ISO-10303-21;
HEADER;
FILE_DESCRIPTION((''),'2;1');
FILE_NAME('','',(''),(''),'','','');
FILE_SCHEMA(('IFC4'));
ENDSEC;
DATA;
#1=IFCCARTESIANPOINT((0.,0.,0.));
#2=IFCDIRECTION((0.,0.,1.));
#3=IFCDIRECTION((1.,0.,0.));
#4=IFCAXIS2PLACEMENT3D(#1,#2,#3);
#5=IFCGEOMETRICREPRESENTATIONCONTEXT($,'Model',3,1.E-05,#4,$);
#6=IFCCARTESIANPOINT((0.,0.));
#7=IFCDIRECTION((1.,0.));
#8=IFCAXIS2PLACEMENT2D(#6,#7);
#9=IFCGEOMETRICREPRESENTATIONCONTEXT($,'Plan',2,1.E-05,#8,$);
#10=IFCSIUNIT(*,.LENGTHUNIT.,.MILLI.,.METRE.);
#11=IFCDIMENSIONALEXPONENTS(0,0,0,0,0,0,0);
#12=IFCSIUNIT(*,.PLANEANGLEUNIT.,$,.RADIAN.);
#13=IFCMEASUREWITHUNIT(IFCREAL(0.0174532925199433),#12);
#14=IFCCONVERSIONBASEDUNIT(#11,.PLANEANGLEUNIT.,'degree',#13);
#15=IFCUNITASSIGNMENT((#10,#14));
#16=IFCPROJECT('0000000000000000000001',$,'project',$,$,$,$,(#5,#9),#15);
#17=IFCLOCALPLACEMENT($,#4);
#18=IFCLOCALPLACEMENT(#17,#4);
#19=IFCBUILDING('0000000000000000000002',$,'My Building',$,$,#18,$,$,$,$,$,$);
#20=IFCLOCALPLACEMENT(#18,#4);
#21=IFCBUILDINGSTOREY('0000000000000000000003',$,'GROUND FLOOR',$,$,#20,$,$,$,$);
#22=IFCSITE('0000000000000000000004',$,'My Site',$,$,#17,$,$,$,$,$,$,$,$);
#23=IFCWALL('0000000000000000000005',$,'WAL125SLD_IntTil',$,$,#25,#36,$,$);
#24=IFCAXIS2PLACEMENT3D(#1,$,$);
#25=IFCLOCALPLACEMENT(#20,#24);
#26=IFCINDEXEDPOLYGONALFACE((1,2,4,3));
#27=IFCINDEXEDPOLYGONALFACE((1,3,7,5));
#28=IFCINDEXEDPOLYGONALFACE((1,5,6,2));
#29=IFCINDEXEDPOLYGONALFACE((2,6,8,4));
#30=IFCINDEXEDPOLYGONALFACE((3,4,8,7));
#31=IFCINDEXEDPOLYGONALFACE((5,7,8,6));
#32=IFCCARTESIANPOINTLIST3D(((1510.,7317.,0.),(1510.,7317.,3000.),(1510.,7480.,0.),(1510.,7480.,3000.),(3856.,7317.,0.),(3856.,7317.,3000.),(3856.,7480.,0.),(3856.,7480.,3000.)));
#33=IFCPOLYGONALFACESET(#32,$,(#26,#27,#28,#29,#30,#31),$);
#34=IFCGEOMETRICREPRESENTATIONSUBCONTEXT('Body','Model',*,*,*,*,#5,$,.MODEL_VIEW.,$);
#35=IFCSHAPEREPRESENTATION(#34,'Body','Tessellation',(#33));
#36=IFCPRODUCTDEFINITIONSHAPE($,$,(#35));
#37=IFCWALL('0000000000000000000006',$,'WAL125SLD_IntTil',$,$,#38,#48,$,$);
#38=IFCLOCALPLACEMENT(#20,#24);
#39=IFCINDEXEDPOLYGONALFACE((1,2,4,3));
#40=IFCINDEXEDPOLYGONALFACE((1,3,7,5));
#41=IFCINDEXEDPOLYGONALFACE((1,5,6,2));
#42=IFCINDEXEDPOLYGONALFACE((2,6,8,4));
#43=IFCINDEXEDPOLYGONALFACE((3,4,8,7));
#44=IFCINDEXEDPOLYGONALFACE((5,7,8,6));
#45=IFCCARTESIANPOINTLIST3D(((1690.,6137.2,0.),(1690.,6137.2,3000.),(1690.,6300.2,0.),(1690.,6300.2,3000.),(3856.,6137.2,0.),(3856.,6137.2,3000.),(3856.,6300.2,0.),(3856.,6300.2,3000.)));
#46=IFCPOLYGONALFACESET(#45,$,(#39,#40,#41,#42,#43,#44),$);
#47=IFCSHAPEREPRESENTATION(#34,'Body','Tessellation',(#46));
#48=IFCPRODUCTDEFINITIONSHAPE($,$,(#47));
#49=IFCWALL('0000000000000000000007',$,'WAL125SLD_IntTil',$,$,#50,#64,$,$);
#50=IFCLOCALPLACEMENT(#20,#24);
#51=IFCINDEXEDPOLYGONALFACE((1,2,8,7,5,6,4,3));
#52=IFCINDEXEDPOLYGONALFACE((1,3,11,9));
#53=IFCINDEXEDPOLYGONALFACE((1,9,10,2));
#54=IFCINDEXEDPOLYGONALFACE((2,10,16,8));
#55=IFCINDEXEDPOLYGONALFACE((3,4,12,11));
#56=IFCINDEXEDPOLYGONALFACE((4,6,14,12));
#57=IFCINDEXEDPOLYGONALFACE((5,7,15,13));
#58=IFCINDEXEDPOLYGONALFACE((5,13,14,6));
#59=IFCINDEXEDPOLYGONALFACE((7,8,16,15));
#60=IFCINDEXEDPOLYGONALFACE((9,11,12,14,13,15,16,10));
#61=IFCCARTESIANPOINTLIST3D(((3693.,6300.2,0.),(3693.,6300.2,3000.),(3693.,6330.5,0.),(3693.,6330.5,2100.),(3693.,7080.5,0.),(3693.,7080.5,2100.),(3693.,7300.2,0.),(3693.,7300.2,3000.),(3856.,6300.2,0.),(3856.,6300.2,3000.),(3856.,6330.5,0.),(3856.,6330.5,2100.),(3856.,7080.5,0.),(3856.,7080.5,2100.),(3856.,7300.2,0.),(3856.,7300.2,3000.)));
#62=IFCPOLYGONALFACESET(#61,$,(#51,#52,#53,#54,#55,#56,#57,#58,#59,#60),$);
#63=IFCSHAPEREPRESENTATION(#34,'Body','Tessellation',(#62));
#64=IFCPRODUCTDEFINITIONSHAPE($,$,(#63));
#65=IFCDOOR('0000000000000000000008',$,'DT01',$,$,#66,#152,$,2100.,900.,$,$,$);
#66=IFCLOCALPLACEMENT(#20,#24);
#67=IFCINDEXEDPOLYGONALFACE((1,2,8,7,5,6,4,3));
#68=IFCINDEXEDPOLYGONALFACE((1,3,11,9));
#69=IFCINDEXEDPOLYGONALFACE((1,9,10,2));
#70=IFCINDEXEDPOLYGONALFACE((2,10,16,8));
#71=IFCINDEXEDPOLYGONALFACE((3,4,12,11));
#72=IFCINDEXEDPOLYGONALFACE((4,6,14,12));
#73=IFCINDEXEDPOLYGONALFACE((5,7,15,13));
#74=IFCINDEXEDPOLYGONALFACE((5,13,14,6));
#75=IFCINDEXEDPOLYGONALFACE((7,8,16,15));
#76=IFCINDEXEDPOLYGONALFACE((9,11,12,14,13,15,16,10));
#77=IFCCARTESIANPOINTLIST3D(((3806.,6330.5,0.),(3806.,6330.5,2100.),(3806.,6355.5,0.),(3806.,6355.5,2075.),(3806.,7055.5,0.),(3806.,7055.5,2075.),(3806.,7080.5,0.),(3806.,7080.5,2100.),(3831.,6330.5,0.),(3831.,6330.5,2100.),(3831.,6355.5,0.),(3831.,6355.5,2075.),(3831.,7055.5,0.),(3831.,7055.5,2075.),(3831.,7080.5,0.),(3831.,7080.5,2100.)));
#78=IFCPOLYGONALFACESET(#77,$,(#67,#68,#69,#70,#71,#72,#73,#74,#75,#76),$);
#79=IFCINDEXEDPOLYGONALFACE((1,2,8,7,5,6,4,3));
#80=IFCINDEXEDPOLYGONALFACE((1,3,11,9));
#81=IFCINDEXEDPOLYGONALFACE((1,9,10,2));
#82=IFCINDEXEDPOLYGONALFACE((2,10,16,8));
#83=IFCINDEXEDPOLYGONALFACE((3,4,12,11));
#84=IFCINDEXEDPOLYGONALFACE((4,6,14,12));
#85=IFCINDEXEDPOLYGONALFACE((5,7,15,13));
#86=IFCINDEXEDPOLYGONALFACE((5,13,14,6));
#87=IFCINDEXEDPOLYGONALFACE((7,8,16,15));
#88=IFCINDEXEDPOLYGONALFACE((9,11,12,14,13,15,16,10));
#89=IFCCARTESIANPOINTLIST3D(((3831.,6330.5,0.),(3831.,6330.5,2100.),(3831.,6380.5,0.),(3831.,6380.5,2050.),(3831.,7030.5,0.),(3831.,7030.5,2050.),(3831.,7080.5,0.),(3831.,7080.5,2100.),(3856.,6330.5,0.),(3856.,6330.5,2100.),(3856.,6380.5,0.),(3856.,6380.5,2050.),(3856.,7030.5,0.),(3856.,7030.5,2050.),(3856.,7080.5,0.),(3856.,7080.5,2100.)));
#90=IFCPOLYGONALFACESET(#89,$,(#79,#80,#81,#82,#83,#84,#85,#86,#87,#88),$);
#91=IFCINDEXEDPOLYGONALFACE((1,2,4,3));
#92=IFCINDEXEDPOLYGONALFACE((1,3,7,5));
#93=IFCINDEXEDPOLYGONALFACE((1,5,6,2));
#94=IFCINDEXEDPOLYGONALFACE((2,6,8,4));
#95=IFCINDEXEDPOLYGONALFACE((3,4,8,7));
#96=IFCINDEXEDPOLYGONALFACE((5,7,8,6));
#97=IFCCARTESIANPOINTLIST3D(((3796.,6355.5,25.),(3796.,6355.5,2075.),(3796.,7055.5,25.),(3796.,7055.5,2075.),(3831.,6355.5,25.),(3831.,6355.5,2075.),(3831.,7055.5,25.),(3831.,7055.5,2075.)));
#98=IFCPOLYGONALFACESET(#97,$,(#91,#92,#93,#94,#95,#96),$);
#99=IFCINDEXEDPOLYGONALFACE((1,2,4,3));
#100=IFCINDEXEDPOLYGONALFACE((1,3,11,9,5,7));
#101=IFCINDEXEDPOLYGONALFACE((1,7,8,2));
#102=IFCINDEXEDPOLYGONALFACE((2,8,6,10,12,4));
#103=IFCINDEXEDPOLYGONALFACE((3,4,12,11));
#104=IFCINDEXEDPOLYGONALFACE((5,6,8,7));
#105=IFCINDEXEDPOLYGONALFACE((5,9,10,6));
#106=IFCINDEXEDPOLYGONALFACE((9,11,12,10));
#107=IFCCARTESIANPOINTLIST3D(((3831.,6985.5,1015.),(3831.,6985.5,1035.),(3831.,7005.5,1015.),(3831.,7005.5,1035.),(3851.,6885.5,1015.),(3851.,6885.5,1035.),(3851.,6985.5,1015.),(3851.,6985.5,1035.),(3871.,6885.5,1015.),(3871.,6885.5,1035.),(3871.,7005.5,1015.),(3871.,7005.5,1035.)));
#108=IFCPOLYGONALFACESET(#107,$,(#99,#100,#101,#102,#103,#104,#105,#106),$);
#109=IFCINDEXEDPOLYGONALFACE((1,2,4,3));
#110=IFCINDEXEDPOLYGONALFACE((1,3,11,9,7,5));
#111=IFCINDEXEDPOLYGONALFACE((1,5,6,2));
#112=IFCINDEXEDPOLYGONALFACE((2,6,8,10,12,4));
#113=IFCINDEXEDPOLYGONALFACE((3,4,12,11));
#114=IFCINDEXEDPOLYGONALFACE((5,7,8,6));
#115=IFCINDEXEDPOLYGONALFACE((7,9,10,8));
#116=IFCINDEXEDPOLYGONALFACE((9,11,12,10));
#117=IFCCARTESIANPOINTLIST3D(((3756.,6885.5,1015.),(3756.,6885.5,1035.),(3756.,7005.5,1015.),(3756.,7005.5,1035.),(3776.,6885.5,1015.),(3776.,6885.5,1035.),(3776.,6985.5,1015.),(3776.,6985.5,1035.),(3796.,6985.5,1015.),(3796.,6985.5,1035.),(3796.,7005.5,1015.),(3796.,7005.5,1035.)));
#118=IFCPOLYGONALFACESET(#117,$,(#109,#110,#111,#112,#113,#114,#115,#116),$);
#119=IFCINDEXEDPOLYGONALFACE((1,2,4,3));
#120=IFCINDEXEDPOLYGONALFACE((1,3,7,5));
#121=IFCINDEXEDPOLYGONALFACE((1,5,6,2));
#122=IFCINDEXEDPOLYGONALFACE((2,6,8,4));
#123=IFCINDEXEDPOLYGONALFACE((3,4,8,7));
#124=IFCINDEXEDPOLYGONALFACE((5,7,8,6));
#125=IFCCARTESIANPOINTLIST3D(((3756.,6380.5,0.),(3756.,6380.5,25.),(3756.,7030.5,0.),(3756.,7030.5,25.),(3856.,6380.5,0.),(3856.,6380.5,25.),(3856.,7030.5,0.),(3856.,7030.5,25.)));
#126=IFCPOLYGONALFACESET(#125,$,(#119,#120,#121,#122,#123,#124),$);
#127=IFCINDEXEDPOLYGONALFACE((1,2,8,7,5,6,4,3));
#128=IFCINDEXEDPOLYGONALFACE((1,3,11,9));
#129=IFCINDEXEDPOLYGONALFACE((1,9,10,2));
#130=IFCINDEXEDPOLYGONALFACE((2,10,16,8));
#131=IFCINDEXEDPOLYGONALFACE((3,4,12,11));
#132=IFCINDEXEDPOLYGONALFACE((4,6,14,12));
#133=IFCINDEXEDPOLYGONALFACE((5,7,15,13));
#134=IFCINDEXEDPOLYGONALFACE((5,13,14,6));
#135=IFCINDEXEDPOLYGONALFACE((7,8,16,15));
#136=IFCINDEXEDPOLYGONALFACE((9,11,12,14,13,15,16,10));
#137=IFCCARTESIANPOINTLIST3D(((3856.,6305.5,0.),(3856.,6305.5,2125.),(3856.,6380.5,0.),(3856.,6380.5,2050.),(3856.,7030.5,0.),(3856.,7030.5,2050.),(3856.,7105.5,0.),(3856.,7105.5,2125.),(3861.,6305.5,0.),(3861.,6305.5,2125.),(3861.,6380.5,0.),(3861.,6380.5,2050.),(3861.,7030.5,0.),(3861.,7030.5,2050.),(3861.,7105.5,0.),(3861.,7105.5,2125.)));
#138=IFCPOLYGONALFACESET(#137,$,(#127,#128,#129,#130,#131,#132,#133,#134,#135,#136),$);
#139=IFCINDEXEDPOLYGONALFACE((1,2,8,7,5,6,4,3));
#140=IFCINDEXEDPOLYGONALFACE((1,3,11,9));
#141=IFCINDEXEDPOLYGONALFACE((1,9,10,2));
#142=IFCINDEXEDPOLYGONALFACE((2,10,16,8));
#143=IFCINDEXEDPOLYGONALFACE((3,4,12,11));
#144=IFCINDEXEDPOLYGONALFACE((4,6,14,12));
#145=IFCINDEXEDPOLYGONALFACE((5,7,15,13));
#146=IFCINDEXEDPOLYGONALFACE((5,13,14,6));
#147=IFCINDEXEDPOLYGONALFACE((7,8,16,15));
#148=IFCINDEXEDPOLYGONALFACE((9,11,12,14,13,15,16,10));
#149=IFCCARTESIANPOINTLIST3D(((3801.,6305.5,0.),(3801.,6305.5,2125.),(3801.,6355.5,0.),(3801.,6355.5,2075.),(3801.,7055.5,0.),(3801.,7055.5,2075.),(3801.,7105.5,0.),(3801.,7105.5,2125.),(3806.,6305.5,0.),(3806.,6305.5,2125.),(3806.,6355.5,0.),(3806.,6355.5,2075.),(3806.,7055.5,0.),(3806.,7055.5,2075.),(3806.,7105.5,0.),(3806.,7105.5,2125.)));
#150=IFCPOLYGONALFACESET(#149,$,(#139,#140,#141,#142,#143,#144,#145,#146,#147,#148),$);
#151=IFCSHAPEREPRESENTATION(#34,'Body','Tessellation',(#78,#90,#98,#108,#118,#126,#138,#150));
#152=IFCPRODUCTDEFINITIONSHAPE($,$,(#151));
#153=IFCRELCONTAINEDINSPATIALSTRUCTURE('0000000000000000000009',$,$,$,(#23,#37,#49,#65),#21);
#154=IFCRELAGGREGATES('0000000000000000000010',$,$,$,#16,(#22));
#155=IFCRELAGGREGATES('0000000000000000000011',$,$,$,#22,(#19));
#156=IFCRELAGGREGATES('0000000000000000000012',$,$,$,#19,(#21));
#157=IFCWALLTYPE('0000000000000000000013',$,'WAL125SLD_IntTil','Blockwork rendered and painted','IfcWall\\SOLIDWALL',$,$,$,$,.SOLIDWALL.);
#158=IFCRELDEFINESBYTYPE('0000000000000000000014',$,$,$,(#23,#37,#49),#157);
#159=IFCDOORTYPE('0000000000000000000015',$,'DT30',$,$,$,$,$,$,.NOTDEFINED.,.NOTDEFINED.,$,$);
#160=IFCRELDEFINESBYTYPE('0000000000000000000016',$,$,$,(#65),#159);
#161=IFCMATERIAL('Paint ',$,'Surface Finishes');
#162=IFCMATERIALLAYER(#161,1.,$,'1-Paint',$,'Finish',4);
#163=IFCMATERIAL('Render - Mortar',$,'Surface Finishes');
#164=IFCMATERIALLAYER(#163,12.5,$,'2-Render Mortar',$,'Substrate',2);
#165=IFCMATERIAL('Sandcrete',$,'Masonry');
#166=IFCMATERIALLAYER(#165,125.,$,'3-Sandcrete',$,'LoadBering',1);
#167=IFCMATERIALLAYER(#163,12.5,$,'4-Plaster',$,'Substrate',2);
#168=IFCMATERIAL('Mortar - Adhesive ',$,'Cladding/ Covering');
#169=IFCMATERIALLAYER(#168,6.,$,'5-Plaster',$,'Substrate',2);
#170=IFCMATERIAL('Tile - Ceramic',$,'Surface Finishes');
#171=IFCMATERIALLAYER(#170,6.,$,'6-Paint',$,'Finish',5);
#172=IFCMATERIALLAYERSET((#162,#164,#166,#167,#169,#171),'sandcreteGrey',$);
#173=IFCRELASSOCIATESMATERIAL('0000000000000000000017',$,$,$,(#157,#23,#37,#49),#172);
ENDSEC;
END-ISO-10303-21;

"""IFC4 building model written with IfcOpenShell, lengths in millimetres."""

from ifc_helpers import new_model, entity, si_unit, converted_unit, frame, origin_with_axes, origin_2d_with_axis, place, context, subcontext, project, spatial, line, indexed_curve, outline, extrude, shape, source, transform, mapped, material, layer, layer_set, layer_usage, type_object, type_shapes, element, fill, save


model = new_model("IFC4")

# Units and contexts
model_context = context("Model", 3, precision=1e-05, world=origin_with_axes())
plan_context = context("Plan", 2, precision=1e-05, world=origin_2d_with_axis())
body_context_1 = subcontext(model_context, "Body", "Model", "MODEL_VIEW")
body_context_2 = subcontext(plan_context, "Body", "Plan", "PLAN_VIEW")
ifc_project = project(units=[si_unit("LENGTHUNIT", "METRE", prefix="MILLI"), converted_unit("PLANEANGLEUNIT", "degree", entity("IfcReal", 0.0174532925199433), si_unit("PLANEANGLEUNIT", "RADIAN"), dimensions=[0, 0, 0, 0, 0, 0, 0])], contexts=[model_context, plan_context])

# Site, building, storey
site_placement = place(None, origin_with_axes())
site = spatial("IfcSite", under=ifc_project, at=site_placement, Name="My Site")
building_placement = place(site_placement, origin_with_axes())
building = spatial("IfcBuilding", under=site, at=building_placement, Name="My Building")
storey_placement = place(building_placement, origin_with_axes())
storey = spatial("IfcBuildingStorey", under=building, at=storey_placement, Name="GROUND FLOOR")

# Walls
ifc_material_1 = material(Name="Paint ", Category="Surface Finishes")
ifc_layer_1 = layer(ifc_material_1, 1.0, Name="1-Paint", Category="Finish", Priority=4)
ifc_material_2 = material(Name="Render - Mortar", Category="Surface Finishes")
ifc_layer_2 = layer(ifc_material_2, 12.5, Name="2-Render Mortar", Category="Substrate", Priority=2)
ifc_material_3 = material(Name="Sandcrete", Category="Masonry")
ifc_layer_3 = layer(ifc_material_3, 125.0, Name="3-Sandcrete", Category="LoadBering", Priority=1)
ifc_layer_4 = layer(ifc_material_2, 12.5, Name="4-Plaster", Category="Substrate", Priority=2)
ifc_material_4 = material(Name="Mortar - Adhesive ", Category="Cladding/ Covering")
ifc_layer_5 = layer(ifc_material_4, 6.0, Name="5-Plaster", Category="Substrate", Priority=2)
ifc_material_5 = material(Name="Tile - Ceramic", Category="Surface Finishes")
ifc_layer_6 = layer(ifc_material_5, 6.0, Name="6-Paint", Category="Finish", Priority=5)
ifc_layer_set_1 = layer_set([ifc_layer_1, ifc_layer_2, ifc_layer_3, ifc_layer_4, ifc_layer_5, ifc_layer_6], Name="sandcreteGrey")
ifc_layer_usage_1 = layer_usage(ifc_layer_set_1, "AXIS2", "POSITIVE", 0.0)
wall_type_1 = type_object("IfcWallType", Name="WAL125SLD_IntTil", Description="Blockwork rendered and painted", ApplicableOccurrence="IfcWall\\SOLIDWALL", PredefinedType="SOLIDWALL", material=ifc_layer_set_1)
wall_1_placement = place(storey_placement, frame((3856.0, 7480.0, 0.0), z_axis=(0.0, 0.0, 1.0), x_axis=(-1.0, 0.0, 0.0)))
element("IfcWall", 1, at=wall_1_placement, inside=storey, type_object=wall_type_1, material=ifc_layer_usage_1, Name="WAL125SLD_IntTil", context=body_context_1, shape_type="SweptSolid", body=[
    extrude(outline(indexed_curve([(0.0, 0.0), (0.0, 163.0), (2346.0, 163.0), (2346.0, 0.0), (0.0, 0.0)], self_intersect=False)), origin_with_axes(), (0.0, 0.0, 1.0), 3000.0),
])
ifc_layer_usage_2 = layer_usage(ifc_layer_set_1, "AXIS2", "POSITIVE", 0.0)
wall_2_placement = place(storey_placement, frame((1690.0, 6137.2, 0.0), z_axis=(0.0, 0.0, 1.0), x_axis=(1.0, 0.0, 0.0)))
element("IfcWall", 2, at=wall_2_placement, inside=storey, type_object=wall_type_1, material=ifc_layer_usage_2, Name="WAL125SLD_IntTil", context=body_context_1, shape_type="SweptSolid", body=[
    extrude(outline(indexed_curve([(0.0, 0.0), (0.0, 163.0), (2166.0, 163.0), (2166.0, 0.0), (0.0, 0.0)], self_intersect=False)), origin_with_axes(), (0.0, 0.0, 1.0), 3000.0),
])

# Wall, opening, door
ifc_layer_usage_3 = layer_usage(ifc_layer_set_1, "AXIS2", "POSITIVE", 0.0)
wall_3_placement = place(storey_placement, frame((3856.0, 6300.2, 0.0), z_axis=(0.0, 0.0, 1.0), x_axis=(0.0, 1.0, 0.0)))
wall_3 = element("IfcWall", 3, at=wall_3_placement, inside=storey, type_object=wall_type_1, material=ifc_layer_usage_3, Name="WAL125SLD_IntTil", context=body_context_1, shape_type="SweptSolid", body=[
    extrude(outline(indexed_curve([(0.0, 0.0), (0.0, 163.0), (1000.0, 163.0), (1000.0, 0.0), (0.0, 0.0)], self_intersect=False)), origin_with_axes(), (0.0, 0.0, 1.0), 3000.0),
])
shared_shape_1 = source(origin_with_axes(), body_context_1, "Body", "SweptSolid", [
    extrude(outline(indexed_curve([(0.0, 0.0), (750.0, 0.0), (750.0, 2100.0), (0.0, 2100.0)], segments=[line(1, 2, 3, 4, 1)])), frame((0.0, -100.0, 0.0), z_axis=(0.0, -1.0, 0.0), x_axis=(1.0, 0.0, 0.0)), (0.0, 0.0, -1.0), 380.0),
])
opening_1_placement = place(wall_3_placement, frame((30.4, 0.0, 0.0), z_axis=(0.0, 0.0, 1.0), x_axis=(1.0, 0.0, 0.0)))
opening_1 = element("IfcOpeningElement", 4, at=opening_1_placement, cuts=wall_3, PredefinedType="OPENING", context=body_context_1, shape_type="MappedRepresentation", body=[
    mapped(shared_shape_1, transform((0.0, 0.0, 0.0), x_axis=(1.0, 0.0, 0.0), y_axis=(0.0, 1.0, 0.0), z_axis=(0.0, 0.0, 1.0), scale=1.0)),
])
door_type = type_object("IfcDoorType", Name="DT30", OperationType="NOTDEFINED", PredefinedType="NOTDEFINED")
shared_shape_2 = source(origin_with_axes(), body_context_1, "Body", "SweptSolid", [
    extrude(outline(indexed_curve([(0.0, 0.0), (0.0, 2100.0), (750.0, 2100.0), (750.0, 0.0), (725.0, 0.0), (725.0, 2075.0), (25.0, 2075.0), (25.0, 0.0)], segments=[line(1, 2, 3, 4, 5, 6, 7, 8, 1)])), frame((0.0, 25.0, 0.0), z_axis=(0.0, -1.0, 0.0), x_axis=(1.0, 0.0, 0.0)), (0.0, 0.0, -1.0), 25.0),
    extrude(outline(indexed_curve([(0.0, 0.0), (0.0, 2100.0), (750.0, 2100.0), (750.0, 0.0), (700.0, 0.0), (700.0, 2050.0), (50.0, 2050.0), (50.0, 0.0)], segments=[line(1, 2, 3, 4, 5, 6, 7, 8, 1)])), frame((0.0, 0.0, 0.0), z_axis=(0.0, -1.0, 0.0), x_axis=(1.0, 0.0, 0.0)), (0.0, 0.0, -1.0), 25.0),
    extrude(outline(indexed_curve([(0.0, 0.0), (700.0, 0.0), (700.0, 35.0), (0.0, 35.0)], segments=[line(1, 2, 3, 4, 1)])), frame((25.0, 25.0, 25.0), z_axis=(0.0, 0.0, 1.0), x_axis=(1.0, 0.0, 0.0)), (0.0, 0.0, 1.0), 2050.0),
    extrude(outline(indexed_curve([(0.0, 0.0), (0.0, -40.0), (-120.0, -40.0), (-120.0, -20.0), (-20.0, -20.0), (-20.0, 0.0)], segments=[line(1, 2, 3, 4, 5, 6, 1)])), frame((675.0, 25.0, 1015.0), z_axis=(0.0, 0.0, 1.0), x_axis=(1.0, 0.0, 0.0)), (0.0, 0.0, 1.0), 20.0),
    extrude(outline(indexed_curve([(0.0, 0.0), (0.0, 40.0), (-120.0, 40.0), (-120.0, 20.0), (-20.0, 20.0), (-20.0, 0.0)], segments=[line(1, 2, 3, 4, 5, 6, 1)])), frame((675.0, 60.0, 1015.0), z_axis=(0.0, 0.0, 1.0), x_axis=(1.0, 0.0, 0.0)), (0.0, 0.0, 1.0), 20.0),
    extrude(outline(indexed_curve([(0.0, 0.0), (650.0, 0.0), (650.0, 100.0), (0.0, 100.0)], segments=[line(1, 2, 3, 4, 1)])), frame((50.0, 0.0, 0.0), z_axis=(0.0, 0.0, 1.0), x_axis=(1.0, 0.0, 0.0)), (0.0, 0.0, 1.0), 25.0),
    extrude(outline(indexed_curve([(0.0, 0.0), (0.0, 2125.0), (800.0, 2125.0), (800.0, 0.0), (725.0, 0.0), (725.0, 2050.0), (75.0, 2050.0), (75.0, 0.0)], segments=[line(1, 2, 3, 4, 5, 6, 7, 8, 1)])), frame((-25.0, -5.0, 0.0), z_axis=(0.0, -1.0, 0.0), x_axis=(1.0, 0.0, 0.0)), (0.0, 0.0, -1.0), 5.0),
    extrude(outline(indexed_curve([(0.0, 0.0), (0.0, 2125.0), (800.0, 2125.0), (800.0, 0.0), (750.0, 0.0), (750.0, 2075.0), (50.0, 2075.0), (50.0, 0.0)], segments=[line(1, 2, 3, 4, 5, 6, 7, 8, 1)])), frame((-25.0, 50.0, 0.0), z_axis=(0.0, -1.0, 0.0), x_axis=(1.0, 0.0, 0.0)), (0.0, 0.0, -1.0), 5.0),
])
shared_shape_3 = source(origin_with_axes(), body_context_2, "Body", "Curve2D", [
    entity("IfcIndexedPolyCurve", entity("IfcCartesianPointList2D", [[0.0, 0.0], [0.0, 50.0], [25.0, 50.0], [25.0, 25.0], [50.0, 25.0], [50.0, 0.0]]), [entity("IfcLineIndex", [1, 2, 3, 4, 5, 6, 1])]),
    entity("IfcIndexedPolyCurve", entity("IfcCartesianPointList2D", [[750.0, 0.0], [750.0, 50.0], [725.0, 50.0], [725.0, 25.0], [700.0, 25.0], [700.0, 0.0]]), [entity("IfcLineIndex", [1, 2, 3, 4, 5, 6, 1])]),
    entity("IfcTrimmedCurve", entity("IfcEllipse", entity("IfcAxis2Placement2D", entity("IfcCartesianPoint", [60.0, 50.0]), entity("IfcDirection", [1.0, 0.0])), 665.0, 700.0), [entity("IfcCartesianPoint", [725.0, 50.0])], [entity("IfcCartesianPoint", [60.0, 750.0])], True, "CARTESIAN"),
    entity("IfcIndexedPolyCurve", entity("IfcCartesianPointList2D", [[25.0, 50.0], [60.0, 50.0], [60.0, 750.0], [25.0, 750.0]]), [entity("IfcLineIndex", [1, 2, 3, 4, 1])]),
])
type_shapes(door_type, [shared_shape_2, shared_shape_3])
door_placement = place(opening_1_placement, frame((0.0, 0.0, 0.0), z_axis=(0.0, 0.0, 1.0), x_axis=(1.0, 0.0, 0.0)))
door = element("IfcDoor", 5, at=door_placement, inside=storey, type_object=door_type, Name="DT01", OverallHeight=2100.0, OverallWidth=900.0, shapes=[
    shape(body_context_1, "Body", "MappedRepresentation", [mapped(shared_shape_2, transform((0.0, 0.0, 0.0), x_axis=(1.0, 0.0, 0.0), y_axis=(0.0, 1.0, 0.0), z_axis=(0.0, 0.0, 1.0), scale=1.0))]),
    shape(body_context_2, "Body", "MappedRepresentation", [mapped(shared_shape_3, transform((0.0, 0.0, 0.0), x_axis=(1.0, 0.0, 0.0), y_axis=(0.0, 1.0, 0.0), z_axis=(0.0, 0.0, 1.0), scale=1.0))]),
])
fill(opening_1, door)

save(model, "model.ifc")
